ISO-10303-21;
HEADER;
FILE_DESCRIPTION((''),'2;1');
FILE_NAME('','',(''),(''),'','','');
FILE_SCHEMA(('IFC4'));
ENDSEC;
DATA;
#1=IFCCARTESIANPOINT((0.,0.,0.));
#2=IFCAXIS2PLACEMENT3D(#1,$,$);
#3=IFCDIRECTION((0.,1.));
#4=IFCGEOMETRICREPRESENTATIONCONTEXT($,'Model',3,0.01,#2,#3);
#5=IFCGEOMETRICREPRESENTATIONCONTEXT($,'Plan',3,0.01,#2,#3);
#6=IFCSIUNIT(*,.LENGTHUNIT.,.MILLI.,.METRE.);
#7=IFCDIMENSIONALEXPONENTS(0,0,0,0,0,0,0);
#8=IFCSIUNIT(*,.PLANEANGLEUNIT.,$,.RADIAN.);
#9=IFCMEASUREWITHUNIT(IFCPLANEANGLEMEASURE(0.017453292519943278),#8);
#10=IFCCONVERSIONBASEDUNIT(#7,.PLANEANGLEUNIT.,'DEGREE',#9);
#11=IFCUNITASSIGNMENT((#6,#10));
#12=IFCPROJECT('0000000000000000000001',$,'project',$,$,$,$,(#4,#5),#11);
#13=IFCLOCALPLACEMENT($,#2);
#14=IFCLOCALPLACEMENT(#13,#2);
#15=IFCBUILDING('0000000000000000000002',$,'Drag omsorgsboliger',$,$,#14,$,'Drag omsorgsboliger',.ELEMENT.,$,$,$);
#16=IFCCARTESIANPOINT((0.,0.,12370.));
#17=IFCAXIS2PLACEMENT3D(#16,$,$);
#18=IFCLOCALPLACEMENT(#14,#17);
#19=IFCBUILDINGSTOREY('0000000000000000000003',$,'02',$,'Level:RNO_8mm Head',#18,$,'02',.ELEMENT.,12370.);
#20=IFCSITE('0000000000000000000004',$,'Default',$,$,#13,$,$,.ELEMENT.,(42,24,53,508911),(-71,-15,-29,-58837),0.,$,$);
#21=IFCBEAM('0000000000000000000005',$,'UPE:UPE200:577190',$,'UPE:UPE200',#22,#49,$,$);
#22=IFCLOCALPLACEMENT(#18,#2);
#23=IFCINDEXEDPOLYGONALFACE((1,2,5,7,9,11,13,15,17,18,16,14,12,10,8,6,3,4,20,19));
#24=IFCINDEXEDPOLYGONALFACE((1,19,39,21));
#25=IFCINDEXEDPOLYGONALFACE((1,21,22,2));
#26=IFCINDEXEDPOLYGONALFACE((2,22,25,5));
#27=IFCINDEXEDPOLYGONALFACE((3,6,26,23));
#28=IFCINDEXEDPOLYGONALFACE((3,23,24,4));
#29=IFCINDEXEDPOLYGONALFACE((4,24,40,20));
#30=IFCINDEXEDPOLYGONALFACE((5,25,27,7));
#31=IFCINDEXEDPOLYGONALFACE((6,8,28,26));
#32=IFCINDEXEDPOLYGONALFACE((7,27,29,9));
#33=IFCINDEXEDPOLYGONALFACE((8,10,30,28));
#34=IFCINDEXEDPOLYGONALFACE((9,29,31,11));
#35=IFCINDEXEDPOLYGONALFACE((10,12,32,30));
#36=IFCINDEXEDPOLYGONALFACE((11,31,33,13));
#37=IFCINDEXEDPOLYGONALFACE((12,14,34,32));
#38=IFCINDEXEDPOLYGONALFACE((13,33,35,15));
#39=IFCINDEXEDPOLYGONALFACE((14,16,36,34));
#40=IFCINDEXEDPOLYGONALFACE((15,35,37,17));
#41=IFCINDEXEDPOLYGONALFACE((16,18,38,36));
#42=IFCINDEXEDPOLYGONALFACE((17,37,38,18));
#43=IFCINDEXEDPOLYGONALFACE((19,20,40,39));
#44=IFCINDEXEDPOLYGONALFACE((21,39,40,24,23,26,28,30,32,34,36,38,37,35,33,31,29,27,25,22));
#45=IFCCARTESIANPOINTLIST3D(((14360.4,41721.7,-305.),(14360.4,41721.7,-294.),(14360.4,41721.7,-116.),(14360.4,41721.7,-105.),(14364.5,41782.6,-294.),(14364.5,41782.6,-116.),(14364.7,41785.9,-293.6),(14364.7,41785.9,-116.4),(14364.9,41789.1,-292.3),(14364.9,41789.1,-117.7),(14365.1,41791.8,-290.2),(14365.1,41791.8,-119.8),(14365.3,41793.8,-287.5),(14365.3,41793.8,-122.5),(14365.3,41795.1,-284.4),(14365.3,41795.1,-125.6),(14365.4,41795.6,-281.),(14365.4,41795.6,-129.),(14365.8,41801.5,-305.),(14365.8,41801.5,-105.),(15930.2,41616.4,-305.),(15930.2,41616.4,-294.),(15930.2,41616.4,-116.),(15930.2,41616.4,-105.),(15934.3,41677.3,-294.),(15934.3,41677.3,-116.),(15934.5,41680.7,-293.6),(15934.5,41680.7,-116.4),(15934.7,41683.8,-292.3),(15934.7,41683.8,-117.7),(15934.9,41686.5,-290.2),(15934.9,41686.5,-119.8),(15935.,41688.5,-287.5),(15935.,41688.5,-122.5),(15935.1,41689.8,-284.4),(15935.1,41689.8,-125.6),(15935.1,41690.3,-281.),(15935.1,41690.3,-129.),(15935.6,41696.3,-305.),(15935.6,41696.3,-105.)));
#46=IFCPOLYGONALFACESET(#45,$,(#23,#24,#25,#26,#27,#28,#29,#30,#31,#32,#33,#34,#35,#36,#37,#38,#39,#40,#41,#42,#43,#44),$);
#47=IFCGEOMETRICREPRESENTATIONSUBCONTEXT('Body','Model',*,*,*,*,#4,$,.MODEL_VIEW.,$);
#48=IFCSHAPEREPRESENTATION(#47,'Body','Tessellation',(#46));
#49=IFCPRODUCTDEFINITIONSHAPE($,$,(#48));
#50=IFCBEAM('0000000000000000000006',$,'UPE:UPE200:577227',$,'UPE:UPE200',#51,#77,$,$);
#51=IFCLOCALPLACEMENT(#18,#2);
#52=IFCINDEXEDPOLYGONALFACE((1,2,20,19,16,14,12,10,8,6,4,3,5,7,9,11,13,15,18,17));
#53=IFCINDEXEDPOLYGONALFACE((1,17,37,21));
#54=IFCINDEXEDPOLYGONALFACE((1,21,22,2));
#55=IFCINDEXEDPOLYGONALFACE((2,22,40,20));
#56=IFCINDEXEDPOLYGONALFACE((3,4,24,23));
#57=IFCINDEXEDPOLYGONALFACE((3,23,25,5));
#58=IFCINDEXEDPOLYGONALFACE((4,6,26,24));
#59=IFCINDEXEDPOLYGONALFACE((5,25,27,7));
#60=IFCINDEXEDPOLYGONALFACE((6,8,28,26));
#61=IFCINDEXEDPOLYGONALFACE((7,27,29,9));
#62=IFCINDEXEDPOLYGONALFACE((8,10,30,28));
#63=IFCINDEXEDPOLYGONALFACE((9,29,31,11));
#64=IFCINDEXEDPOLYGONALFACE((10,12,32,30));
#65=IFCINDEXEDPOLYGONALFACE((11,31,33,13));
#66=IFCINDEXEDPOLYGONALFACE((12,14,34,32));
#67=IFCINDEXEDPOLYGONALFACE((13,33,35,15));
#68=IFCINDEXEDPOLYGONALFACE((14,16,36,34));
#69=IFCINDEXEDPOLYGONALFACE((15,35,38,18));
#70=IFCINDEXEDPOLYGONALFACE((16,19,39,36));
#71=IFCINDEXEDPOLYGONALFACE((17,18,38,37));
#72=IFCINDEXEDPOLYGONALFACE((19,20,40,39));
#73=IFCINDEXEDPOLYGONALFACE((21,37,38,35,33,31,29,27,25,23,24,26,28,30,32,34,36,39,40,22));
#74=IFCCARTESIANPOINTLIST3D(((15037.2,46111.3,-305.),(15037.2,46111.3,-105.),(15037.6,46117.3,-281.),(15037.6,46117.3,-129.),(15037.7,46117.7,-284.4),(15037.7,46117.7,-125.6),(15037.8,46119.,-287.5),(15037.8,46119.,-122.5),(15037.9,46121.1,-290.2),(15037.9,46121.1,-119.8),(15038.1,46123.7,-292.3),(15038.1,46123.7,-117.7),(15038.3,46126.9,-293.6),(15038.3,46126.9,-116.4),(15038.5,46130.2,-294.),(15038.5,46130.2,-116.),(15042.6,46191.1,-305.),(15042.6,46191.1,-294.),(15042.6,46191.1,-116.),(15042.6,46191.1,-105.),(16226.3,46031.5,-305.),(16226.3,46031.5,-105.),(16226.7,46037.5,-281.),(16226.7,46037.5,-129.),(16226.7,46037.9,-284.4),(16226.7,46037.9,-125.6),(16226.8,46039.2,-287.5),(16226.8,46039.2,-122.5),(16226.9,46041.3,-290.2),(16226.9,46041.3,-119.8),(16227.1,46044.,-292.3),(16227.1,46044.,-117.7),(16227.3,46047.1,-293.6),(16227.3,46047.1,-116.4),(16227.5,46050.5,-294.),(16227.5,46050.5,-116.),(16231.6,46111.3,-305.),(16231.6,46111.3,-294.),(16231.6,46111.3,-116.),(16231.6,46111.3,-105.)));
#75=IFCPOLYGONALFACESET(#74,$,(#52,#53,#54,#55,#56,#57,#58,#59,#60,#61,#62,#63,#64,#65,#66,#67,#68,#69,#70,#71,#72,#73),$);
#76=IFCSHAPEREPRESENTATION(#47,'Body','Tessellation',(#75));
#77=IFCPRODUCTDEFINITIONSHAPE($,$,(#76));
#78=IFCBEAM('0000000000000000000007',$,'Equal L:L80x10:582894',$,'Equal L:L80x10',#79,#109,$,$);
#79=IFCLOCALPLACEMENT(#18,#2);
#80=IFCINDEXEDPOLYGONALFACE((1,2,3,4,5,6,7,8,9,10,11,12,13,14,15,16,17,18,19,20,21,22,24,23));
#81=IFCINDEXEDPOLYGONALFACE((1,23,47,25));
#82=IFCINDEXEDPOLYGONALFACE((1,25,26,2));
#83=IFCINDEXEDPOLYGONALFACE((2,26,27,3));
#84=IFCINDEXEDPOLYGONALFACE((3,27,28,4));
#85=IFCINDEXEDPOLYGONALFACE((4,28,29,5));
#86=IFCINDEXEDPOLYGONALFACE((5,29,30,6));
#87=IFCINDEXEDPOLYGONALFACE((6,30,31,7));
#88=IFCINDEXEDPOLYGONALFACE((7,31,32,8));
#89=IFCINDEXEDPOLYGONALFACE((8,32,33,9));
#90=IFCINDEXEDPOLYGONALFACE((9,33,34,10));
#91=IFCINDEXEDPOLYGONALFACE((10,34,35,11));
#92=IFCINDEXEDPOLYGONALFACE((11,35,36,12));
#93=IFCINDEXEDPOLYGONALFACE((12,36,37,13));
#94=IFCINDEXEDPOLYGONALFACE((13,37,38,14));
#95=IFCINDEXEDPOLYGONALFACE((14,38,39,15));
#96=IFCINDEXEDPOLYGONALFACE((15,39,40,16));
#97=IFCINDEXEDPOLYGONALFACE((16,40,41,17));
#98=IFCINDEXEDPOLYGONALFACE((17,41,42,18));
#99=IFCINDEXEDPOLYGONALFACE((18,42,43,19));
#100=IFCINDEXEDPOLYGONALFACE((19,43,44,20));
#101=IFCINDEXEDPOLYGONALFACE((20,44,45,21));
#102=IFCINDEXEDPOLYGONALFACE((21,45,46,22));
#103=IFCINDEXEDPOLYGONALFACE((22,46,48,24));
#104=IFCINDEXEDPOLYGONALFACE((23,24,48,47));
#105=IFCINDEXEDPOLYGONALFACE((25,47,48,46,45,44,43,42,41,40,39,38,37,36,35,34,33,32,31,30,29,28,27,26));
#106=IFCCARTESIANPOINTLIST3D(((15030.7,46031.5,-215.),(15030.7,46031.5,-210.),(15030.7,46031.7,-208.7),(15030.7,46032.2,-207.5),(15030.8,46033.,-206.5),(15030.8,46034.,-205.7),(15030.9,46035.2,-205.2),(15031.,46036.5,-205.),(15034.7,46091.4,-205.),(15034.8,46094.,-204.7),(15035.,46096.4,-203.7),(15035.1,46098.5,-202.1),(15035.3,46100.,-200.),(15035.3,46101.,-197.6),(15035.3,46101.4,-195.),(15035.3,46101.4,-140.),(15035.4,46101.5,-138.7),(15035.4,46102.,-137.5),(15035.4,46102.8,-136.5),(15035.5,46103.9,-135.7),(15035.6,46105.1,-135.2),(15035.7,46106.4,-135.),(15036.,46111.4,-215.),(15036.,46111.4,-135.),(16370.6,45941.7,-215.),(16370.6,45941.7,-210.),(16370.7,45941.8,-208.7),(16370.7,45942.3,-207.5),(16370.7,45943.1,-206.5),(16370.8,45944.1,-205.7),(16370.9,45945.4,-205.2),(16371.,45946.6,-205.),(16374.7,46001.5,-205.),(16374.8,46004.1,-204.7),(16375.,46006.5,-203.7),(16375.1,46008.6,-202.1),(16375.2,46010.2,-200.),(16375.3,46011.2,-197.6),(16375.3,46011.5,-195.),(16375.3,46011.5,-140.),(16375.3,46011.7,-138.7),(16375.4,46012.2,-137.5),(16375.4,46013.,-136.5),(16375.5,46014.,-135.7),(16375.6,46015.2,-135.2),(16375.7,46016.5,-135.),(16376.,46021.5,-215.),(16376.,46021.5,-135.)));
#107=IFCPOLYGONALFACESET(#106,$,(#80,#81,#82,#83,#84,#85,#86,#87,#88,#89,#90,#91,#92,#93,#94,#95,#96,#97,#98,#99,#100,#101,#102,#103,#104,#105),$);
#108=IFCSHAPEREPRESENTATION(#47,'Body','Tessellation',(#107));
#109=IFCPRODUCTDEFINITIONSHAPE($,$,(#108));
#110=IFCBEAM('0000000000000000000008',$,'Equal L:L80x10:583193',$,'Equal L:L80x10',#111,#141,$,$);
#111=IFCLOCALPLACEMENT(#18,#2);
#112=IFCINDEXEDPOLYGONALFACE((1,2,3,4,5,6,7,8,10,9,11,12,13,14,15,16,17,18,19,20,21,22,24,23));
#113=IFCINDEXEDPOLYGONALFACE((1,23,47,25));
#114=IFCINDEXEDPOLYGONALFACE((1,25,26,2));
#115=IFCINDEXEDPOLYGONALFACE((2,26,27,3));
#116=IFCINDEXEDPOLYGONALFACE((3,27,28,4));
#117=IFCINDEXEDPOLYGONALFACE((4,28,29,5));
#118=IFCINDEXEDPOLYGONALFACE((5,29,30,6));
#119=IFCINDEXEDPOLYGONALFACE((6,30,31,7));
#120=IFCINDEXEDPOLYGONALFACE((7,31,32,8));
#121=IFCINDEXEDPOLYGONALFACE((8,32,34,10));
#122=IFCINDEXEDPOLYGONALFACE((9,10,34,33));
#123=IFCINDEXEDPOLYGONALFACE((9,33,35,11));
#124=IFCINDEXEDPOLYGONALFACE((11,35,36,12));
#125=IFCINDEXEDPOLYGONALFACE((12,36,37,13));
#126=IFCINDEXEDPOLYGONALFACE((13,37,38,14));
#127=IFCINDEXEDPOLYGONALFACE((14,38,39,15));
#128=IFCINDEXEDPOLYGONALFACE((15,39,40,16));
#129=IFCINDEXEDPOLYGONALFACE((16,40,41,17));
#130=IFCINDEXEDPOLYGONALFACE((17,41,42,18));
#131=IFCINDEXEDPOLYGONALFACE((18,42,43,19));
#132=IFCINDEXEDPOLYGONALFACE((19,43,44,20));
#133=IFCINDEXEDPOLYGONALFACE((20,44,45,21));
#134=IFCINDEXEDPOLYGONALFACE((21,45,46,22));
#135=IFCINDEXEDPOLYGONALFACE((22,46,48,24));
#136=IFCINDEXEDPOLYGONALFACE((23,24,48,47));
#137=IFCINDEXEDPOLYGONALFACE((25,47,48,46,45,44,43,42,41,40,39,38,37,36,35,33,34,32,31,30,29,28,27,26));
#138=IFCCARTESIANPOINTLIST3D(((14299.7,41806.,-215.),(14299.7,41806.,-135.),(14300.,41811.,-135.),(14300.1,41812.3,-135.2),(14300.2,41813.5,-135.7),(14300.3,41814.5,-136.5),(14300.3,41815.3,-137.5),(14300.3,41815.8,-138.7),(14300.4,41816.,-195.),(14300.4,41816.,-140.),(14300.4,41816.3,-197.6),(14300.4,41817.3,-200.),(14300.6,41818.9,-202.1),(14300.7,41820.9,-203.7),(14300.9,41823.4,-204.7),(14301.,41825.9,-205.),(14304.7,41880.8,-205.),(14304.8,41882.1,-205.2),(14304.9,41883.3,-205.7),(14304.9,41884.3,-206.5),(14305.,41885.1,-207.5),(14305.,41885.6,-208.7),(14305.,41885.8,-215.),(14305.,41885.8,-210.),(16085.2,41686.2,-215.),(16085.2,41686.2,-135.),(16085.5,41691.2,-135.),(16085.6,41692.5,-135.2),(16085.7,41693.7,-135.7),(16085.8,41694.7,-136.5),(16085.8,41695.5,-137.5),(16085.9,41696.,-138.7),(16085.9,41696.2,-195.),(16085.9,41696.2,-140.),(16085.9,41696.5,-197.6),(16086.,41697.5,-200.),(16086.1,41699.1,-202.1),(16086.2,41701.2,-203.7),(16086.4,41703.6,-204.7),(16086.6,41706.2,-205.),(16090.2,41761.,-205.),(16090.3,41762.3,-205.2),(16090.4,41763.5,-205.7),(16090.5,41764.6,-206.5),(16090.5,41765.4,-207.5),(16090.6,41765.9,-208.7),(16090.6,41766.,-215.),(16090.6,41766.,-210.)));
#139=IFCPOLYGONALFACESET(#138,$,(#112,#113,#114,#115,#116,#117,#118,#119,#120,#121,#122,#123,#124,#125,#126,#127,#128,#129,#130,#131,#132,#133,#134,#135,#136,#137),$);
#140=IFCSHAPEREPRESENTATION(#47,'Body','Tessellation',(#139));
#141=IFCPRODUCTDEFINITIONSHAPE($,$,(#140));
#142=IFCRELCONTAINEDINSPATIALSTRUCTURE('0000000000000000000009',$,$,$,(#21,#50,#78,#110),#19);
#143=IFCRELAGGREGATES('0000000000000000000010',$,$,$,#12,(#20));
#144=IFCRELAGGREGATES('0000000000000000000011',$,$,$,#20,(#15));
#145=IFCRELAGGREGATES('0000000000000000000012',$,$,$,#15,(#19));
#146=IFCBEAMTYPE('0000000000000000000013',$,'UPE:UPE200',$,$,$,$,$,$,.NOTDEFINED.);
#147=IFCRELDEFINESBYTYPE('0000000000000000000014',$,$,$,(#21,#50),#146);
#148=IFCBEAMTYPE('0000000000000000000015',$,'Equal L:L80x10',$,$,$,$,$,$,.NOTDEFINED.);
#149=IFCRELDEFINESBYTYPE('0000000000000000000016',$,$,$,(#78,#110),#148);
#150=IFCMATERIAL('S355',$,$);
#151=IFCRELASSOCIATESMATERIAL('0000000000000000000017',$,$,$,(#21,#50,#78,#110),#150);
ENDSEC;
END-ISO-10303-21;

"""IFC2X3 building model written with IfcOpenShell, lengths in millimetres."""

from ifc_helpers import new_model, entity, si_unit, converted_unit, direction, frame, frame_2d, origin, place, context, subcontext, project, spatial, polyline, circle_curve, parameter, trimmed, segment, composite_curve, outline, extrude, material, type_object, element, save


model = new_model("IFC2X3")

# Units and contexts
model_context = context("Model", 3, precision=0.01, world=origin(), true_north=direction((0.0, 1.0)))
plan_context = context("Plan", 3, precision=0.01, world=origin(), true_north=direction((0.0, 1.0)))
body_context = subcontext(model_context, "Body", "Model", "MODEL_VIEW")
ifc_project = project(units=[si_unit("LENGTHUNIT", "METRE", prefix="MILLI"), converted_unit("PLANEANGLEUNIT", "DEGREE", entity("IfcPlaneAngleMeasure", 0.017453292519943278), si_unit("PLANEANGLEUNIT", "RADIAN"), dimensions=[0, 0, 0, 0, 0, 0, 0])], contexts=[model_context, plan_context])

# Site, building, storey
site_placement = place(None, origin())
site = spatial("IfcSite", under=ifc_project, at=site_placement, Name="Default", CompositionType="ELEMENT", RefLatitude=(42, 24, 53, 508911), RefLongitude=(-71, -15, -29, -58837), RefElevation=0.0)
building_placement = place(site_placement, origin())
building = spatial("IfcBuilding", under=site, at=building_placement, Name="Drag omsorgsboliger", LongName="Drag omsorgsboliger", CompositionType="ELEMENT")
storey_placement = place(building_placement, frame((0.0, 0.0, 12370.0)))
storey = spatial("IfcBuildingStorey", under=building, at=storey_placement, Name="02", ObjectType="Level:RNO_8mm Head", LongName="02", CompositionType="ELEMENT", Elevation=12370.0)

# Beams
ifc_material_1 = material(Name="S355")
beam_type_1 = type_object("IfcBeamType", Name="UPE:UPE200", PredefinedType="NOTDEFINED")
beam_1_placement = place(storey_placement, frame((15933.8, 41670.7, -105.0), z_axis=(0.0, 0.0, 1.0), x_axis=(-0.997758, 0.066923, 0.0)))
element("IfcBeam", 1, at=beam_1_placement, inside=storey, type_object=beam_type_1, material=ifc_material_1, Name="UPE:UPE200:577190", ObjectType="UPE:UPE200", context=body_context, shape_type="SweptSolid", body=[
    extrude(outline(composite_curve([segment(polyline([(-100.0, -37.0), (100.0, -37.0)]), True, "CONTINUOUS"), segment(polyline([(100.0, -37.0), (100.0, 43.0)]), True, "CONTINUOUS"), segment(polyline([(100.0, 43.0), (89.0, 43.0)]), True, "CONTINUOUS"), segment(polyline([(89.0, 43.0), (89.0, -18.0)]), True, "CONTINUOUS"), segment(trimmed(circle_curve(frame_2d((76.0, -18.0), x_axis=(1.0, 0.0)), 13.0), [parameter(270.0)], [parameter(0.0)], True, "PARAMETER"), False, "CONTINUOUS"), segment(polyline([(76.0, -31.0), (-76.0, -31.0)]), True, "CONTINUOUS"), segment(trimmed(circle_curve(frame_2d((-76.0, -18.0), x_axis=(0.0, -1.0)), 13.0), [parameter(270.0)], [parameter(0.0)], True, "PARAMETER"), False, "CONTINUOUS"), segment(polyline([(-89.0, -18.0), (-89.0, 43.0)]), True, "CONTINUOUS"), segment(polyline([(-89.0, 43.0), (-100.0, 43.0)]), True, "CONTINUOUS"), segment(polyline([(-100.0, 43.0), (-100.0, -37.0)]), True, "CONTINUOUS")], self_intersect=False)), frame((0.0, 11.4, -100.0), z_axis=(1.0, 0.0, 0.0), x_axis=(0.0, 0.0, -1.0)), (0.0, 0.0, 1.0), 1573.3),
])
beam_2_placement = place(storey_placement, frame((16308.3, 46051.7, -105.0), z_axis=(0.0, 0.0, 1.0), x_axis=(-0.997758, 0.066923, 0.0)))
element("IfcBeam", 2, at=beam_2_placement, inside=storey, type_object=beam_type_1, material=ifc_material_1, Name="UPE:UPE200:577227", ObjectType="UPE:UPE200", context=body_context, shape_type="SweptSolid", body=[
    extrude(outline(composite_curve([segment(polyline([(-100.0, -43.0), (-89.0, -43.0)]), True, "CONTINUOUS"), segment(polyline([(-89.0, -43.0), (-89.0, 18.0)]), True, "CONTINUOUS"), segment(trimmed(circle_curve(frame_2d((-76.0, 18.0), x_axis=(-1.0, 0.0)), 13.0), [parameter(270.0)], [parameter(0.0)], True, "PARAMETER"), False, "CONTINUOUS"), segment(polyline([(-76.0, 31.0), (76.0, 31.0)]), True, "CONTINUOUS"), segment(trimmed(circle_curve(frame_2d((76.0, 18.0), x_axis=(0.0, 1.0)), 13.0), [parameter(270.0)], [parameter(0.0)], True, "PARAMETER"), False, "CONTINUOUS"), segment(polyline([(89.0, 18.0), (89.0, -43.0)]), True, "CONTINUOUS"), segment(polyline([(89.0, -43.0), (100.0, -43.0)]), True, "CONTINUOUS"), segment(polyline([(100.0, -43.0), (100.0, 37.0)]), True, "CONTINUOUS"), segment(polyline([(100.0, 37.0), (-100.0, 37.0)]), True, "CONTINUOUS"), segment(polyline([(-100.0, 37.0), (-100.0, -43.0)]), True, "CONTINUOUS")], self_intersect=False)), frame((80.5, -11.4, -100.0), z_axis=(1.0, 0.0, 0.0), x_axis=(0.0, 0.0, -1.0)), (0.0, 0.0, 1.0), 1191.7),
])
beam_type_2 = type_object("IfcBeamType", Name="Equal L:L80x10", PredefinedType="NOTDEFINED")
beam_3_placement = place(storey_placement, frame((16304.6, 46002.8, -135.0), z_axis=(0.0, 0.0, 1.0), x_axis=(-0.997758, 0.066923, 0.0)))
element("IfcBeam", 3, at=beam_3_placement, inside=storey, type_object=beam_type_2, material=ifc_material_1, Name="Equal L:L80x10:582894", ObjectType="Equal L:L80x10", context=body_context, shape_type="SweptSolid", body=[
    extrude(outline(composite_curve([segment(polyline([(-48.9, -31.1), (31.1, -31.1)]), True, "CONTINUOUS"), segment(polyline([(31.1, -31.1), (31.1, 48.9)]), True, "CONTINUOUS"), segment(polyline([(31.1, 48.9), (26.1, 48.9)]), True, "CONTINUOUS"), segment(trimmed(circle_curve(frame_2d((26.1, 43.9), x_axis=(0.0, 1.0)), 5.0), [parameter(0.0)], [parameter(90.0)], True, "PARAMETER"), True, "CONTINUOUS"), segment(polyline([(21.1, 43.9), (21.1, -11.1)]), True, "CONTINUOUS"), segment(trimmed(circle_curve(frame_2d((11.1, -11.1), x_axis=(1.0, 0.0)), 10.0), [parameter(270.0)], [parameter(0.0)], True, "PARAMETER"), False, "CONTINUOUS"), segment(polyline([(11.1, -21.1), (-43.9, -21.1)]), True, "CONTINUOUS"), segment(trimmed(circle_curve(frame_2d((-43.9, -26.1), x_axis=(0.0, 1.0)), 5.0), [parameter(0.0)], [parameter(90.0)], True, "PARAMETER"), True, "CONTINUOUS"), segment(polyline([(-48.9, -26.1), (-48.9, -31.1)]), True, "CONTINUOUS")], self_intersect=False)), frame((-70.0, 7.7, -48.9), z_axis=(1.0, 0.0, 0.0), x_axis=(0.0, 0.0, -1.0)), (0.0, 0.0, 1.0), 1343.0),
])
beam_4_placement = place(storey_placement, frame((16096.8, 41708.9, -135.0), z_axis=(0.0, 0.0, 1.0), x_axis=(-0.997758, 0.066923, 0.0)))
element("IfcBeam", 4, at=beam_4_placement, inside=storey, type_object=beam_type_2, material=ifc_material_1, Name="Equal L:L80x10:583193", ObjectType="Equal L:L80x10", context=body_context, shape_type="SweptSolid", body=[
    extrude(outline(composite_curve([segment(polyline([(26.1, -48.9), (31.1, -48.9)]), True, "CONTINUOUS"), segment(polyline([(31.1, -48.9), (31.1, 31.1)]), True, "CONTINUOUS"), segment(polyline([(31.1, 31.1), (-48.9, 31.1)]), True, "CONTINUOUS"), segment(polyline([(-48.9, 31.1), (-48.9, 26.1)]), True, "CONTINUOUS"), segment(trimmed(circle_curve(frame_2d((-43.9, 26.1), x_axis=(-1.0, 0.0)), 5.0), [parameter(0.0)], [parameter(90.0)], True, "PARAMETER"), True, "CONTINUOUS"), segment(polyline([(-43.9, 21.1), (11.1, 21.1)]), True, "CONTINUOUS"), segment(trimmed(circle_curve(frame_2d((11.1, 11.1), x_axis=(0.0, 1.0)), 10.0), [parameter(270.0)], [parameter(0.0)], True, "PARAMETER"), False, "CONTINUOUS"), segment(polyline([(21.1, 11.1), (21.1, -43.9)]), True, "CONTINUOUS"), segment(trimmed(circle_curve(frame_2d((26.1, -43.9), x_axis=(-1.0, 0.0)), 5.0), [parameter(0.0)], [parameter(90.0)], True, "PARAMETER"), True, "CONTINUOUS")], self_intersect=False)), frame((10.0, -7.7, -48.9), z_axis=(1.0, 0.0, 0.0), x_axis=(0.0, 0.0, -1.0)), (0.0, 0.0, 1.0), 1789.5),
])

save(model, "model.ifc")
